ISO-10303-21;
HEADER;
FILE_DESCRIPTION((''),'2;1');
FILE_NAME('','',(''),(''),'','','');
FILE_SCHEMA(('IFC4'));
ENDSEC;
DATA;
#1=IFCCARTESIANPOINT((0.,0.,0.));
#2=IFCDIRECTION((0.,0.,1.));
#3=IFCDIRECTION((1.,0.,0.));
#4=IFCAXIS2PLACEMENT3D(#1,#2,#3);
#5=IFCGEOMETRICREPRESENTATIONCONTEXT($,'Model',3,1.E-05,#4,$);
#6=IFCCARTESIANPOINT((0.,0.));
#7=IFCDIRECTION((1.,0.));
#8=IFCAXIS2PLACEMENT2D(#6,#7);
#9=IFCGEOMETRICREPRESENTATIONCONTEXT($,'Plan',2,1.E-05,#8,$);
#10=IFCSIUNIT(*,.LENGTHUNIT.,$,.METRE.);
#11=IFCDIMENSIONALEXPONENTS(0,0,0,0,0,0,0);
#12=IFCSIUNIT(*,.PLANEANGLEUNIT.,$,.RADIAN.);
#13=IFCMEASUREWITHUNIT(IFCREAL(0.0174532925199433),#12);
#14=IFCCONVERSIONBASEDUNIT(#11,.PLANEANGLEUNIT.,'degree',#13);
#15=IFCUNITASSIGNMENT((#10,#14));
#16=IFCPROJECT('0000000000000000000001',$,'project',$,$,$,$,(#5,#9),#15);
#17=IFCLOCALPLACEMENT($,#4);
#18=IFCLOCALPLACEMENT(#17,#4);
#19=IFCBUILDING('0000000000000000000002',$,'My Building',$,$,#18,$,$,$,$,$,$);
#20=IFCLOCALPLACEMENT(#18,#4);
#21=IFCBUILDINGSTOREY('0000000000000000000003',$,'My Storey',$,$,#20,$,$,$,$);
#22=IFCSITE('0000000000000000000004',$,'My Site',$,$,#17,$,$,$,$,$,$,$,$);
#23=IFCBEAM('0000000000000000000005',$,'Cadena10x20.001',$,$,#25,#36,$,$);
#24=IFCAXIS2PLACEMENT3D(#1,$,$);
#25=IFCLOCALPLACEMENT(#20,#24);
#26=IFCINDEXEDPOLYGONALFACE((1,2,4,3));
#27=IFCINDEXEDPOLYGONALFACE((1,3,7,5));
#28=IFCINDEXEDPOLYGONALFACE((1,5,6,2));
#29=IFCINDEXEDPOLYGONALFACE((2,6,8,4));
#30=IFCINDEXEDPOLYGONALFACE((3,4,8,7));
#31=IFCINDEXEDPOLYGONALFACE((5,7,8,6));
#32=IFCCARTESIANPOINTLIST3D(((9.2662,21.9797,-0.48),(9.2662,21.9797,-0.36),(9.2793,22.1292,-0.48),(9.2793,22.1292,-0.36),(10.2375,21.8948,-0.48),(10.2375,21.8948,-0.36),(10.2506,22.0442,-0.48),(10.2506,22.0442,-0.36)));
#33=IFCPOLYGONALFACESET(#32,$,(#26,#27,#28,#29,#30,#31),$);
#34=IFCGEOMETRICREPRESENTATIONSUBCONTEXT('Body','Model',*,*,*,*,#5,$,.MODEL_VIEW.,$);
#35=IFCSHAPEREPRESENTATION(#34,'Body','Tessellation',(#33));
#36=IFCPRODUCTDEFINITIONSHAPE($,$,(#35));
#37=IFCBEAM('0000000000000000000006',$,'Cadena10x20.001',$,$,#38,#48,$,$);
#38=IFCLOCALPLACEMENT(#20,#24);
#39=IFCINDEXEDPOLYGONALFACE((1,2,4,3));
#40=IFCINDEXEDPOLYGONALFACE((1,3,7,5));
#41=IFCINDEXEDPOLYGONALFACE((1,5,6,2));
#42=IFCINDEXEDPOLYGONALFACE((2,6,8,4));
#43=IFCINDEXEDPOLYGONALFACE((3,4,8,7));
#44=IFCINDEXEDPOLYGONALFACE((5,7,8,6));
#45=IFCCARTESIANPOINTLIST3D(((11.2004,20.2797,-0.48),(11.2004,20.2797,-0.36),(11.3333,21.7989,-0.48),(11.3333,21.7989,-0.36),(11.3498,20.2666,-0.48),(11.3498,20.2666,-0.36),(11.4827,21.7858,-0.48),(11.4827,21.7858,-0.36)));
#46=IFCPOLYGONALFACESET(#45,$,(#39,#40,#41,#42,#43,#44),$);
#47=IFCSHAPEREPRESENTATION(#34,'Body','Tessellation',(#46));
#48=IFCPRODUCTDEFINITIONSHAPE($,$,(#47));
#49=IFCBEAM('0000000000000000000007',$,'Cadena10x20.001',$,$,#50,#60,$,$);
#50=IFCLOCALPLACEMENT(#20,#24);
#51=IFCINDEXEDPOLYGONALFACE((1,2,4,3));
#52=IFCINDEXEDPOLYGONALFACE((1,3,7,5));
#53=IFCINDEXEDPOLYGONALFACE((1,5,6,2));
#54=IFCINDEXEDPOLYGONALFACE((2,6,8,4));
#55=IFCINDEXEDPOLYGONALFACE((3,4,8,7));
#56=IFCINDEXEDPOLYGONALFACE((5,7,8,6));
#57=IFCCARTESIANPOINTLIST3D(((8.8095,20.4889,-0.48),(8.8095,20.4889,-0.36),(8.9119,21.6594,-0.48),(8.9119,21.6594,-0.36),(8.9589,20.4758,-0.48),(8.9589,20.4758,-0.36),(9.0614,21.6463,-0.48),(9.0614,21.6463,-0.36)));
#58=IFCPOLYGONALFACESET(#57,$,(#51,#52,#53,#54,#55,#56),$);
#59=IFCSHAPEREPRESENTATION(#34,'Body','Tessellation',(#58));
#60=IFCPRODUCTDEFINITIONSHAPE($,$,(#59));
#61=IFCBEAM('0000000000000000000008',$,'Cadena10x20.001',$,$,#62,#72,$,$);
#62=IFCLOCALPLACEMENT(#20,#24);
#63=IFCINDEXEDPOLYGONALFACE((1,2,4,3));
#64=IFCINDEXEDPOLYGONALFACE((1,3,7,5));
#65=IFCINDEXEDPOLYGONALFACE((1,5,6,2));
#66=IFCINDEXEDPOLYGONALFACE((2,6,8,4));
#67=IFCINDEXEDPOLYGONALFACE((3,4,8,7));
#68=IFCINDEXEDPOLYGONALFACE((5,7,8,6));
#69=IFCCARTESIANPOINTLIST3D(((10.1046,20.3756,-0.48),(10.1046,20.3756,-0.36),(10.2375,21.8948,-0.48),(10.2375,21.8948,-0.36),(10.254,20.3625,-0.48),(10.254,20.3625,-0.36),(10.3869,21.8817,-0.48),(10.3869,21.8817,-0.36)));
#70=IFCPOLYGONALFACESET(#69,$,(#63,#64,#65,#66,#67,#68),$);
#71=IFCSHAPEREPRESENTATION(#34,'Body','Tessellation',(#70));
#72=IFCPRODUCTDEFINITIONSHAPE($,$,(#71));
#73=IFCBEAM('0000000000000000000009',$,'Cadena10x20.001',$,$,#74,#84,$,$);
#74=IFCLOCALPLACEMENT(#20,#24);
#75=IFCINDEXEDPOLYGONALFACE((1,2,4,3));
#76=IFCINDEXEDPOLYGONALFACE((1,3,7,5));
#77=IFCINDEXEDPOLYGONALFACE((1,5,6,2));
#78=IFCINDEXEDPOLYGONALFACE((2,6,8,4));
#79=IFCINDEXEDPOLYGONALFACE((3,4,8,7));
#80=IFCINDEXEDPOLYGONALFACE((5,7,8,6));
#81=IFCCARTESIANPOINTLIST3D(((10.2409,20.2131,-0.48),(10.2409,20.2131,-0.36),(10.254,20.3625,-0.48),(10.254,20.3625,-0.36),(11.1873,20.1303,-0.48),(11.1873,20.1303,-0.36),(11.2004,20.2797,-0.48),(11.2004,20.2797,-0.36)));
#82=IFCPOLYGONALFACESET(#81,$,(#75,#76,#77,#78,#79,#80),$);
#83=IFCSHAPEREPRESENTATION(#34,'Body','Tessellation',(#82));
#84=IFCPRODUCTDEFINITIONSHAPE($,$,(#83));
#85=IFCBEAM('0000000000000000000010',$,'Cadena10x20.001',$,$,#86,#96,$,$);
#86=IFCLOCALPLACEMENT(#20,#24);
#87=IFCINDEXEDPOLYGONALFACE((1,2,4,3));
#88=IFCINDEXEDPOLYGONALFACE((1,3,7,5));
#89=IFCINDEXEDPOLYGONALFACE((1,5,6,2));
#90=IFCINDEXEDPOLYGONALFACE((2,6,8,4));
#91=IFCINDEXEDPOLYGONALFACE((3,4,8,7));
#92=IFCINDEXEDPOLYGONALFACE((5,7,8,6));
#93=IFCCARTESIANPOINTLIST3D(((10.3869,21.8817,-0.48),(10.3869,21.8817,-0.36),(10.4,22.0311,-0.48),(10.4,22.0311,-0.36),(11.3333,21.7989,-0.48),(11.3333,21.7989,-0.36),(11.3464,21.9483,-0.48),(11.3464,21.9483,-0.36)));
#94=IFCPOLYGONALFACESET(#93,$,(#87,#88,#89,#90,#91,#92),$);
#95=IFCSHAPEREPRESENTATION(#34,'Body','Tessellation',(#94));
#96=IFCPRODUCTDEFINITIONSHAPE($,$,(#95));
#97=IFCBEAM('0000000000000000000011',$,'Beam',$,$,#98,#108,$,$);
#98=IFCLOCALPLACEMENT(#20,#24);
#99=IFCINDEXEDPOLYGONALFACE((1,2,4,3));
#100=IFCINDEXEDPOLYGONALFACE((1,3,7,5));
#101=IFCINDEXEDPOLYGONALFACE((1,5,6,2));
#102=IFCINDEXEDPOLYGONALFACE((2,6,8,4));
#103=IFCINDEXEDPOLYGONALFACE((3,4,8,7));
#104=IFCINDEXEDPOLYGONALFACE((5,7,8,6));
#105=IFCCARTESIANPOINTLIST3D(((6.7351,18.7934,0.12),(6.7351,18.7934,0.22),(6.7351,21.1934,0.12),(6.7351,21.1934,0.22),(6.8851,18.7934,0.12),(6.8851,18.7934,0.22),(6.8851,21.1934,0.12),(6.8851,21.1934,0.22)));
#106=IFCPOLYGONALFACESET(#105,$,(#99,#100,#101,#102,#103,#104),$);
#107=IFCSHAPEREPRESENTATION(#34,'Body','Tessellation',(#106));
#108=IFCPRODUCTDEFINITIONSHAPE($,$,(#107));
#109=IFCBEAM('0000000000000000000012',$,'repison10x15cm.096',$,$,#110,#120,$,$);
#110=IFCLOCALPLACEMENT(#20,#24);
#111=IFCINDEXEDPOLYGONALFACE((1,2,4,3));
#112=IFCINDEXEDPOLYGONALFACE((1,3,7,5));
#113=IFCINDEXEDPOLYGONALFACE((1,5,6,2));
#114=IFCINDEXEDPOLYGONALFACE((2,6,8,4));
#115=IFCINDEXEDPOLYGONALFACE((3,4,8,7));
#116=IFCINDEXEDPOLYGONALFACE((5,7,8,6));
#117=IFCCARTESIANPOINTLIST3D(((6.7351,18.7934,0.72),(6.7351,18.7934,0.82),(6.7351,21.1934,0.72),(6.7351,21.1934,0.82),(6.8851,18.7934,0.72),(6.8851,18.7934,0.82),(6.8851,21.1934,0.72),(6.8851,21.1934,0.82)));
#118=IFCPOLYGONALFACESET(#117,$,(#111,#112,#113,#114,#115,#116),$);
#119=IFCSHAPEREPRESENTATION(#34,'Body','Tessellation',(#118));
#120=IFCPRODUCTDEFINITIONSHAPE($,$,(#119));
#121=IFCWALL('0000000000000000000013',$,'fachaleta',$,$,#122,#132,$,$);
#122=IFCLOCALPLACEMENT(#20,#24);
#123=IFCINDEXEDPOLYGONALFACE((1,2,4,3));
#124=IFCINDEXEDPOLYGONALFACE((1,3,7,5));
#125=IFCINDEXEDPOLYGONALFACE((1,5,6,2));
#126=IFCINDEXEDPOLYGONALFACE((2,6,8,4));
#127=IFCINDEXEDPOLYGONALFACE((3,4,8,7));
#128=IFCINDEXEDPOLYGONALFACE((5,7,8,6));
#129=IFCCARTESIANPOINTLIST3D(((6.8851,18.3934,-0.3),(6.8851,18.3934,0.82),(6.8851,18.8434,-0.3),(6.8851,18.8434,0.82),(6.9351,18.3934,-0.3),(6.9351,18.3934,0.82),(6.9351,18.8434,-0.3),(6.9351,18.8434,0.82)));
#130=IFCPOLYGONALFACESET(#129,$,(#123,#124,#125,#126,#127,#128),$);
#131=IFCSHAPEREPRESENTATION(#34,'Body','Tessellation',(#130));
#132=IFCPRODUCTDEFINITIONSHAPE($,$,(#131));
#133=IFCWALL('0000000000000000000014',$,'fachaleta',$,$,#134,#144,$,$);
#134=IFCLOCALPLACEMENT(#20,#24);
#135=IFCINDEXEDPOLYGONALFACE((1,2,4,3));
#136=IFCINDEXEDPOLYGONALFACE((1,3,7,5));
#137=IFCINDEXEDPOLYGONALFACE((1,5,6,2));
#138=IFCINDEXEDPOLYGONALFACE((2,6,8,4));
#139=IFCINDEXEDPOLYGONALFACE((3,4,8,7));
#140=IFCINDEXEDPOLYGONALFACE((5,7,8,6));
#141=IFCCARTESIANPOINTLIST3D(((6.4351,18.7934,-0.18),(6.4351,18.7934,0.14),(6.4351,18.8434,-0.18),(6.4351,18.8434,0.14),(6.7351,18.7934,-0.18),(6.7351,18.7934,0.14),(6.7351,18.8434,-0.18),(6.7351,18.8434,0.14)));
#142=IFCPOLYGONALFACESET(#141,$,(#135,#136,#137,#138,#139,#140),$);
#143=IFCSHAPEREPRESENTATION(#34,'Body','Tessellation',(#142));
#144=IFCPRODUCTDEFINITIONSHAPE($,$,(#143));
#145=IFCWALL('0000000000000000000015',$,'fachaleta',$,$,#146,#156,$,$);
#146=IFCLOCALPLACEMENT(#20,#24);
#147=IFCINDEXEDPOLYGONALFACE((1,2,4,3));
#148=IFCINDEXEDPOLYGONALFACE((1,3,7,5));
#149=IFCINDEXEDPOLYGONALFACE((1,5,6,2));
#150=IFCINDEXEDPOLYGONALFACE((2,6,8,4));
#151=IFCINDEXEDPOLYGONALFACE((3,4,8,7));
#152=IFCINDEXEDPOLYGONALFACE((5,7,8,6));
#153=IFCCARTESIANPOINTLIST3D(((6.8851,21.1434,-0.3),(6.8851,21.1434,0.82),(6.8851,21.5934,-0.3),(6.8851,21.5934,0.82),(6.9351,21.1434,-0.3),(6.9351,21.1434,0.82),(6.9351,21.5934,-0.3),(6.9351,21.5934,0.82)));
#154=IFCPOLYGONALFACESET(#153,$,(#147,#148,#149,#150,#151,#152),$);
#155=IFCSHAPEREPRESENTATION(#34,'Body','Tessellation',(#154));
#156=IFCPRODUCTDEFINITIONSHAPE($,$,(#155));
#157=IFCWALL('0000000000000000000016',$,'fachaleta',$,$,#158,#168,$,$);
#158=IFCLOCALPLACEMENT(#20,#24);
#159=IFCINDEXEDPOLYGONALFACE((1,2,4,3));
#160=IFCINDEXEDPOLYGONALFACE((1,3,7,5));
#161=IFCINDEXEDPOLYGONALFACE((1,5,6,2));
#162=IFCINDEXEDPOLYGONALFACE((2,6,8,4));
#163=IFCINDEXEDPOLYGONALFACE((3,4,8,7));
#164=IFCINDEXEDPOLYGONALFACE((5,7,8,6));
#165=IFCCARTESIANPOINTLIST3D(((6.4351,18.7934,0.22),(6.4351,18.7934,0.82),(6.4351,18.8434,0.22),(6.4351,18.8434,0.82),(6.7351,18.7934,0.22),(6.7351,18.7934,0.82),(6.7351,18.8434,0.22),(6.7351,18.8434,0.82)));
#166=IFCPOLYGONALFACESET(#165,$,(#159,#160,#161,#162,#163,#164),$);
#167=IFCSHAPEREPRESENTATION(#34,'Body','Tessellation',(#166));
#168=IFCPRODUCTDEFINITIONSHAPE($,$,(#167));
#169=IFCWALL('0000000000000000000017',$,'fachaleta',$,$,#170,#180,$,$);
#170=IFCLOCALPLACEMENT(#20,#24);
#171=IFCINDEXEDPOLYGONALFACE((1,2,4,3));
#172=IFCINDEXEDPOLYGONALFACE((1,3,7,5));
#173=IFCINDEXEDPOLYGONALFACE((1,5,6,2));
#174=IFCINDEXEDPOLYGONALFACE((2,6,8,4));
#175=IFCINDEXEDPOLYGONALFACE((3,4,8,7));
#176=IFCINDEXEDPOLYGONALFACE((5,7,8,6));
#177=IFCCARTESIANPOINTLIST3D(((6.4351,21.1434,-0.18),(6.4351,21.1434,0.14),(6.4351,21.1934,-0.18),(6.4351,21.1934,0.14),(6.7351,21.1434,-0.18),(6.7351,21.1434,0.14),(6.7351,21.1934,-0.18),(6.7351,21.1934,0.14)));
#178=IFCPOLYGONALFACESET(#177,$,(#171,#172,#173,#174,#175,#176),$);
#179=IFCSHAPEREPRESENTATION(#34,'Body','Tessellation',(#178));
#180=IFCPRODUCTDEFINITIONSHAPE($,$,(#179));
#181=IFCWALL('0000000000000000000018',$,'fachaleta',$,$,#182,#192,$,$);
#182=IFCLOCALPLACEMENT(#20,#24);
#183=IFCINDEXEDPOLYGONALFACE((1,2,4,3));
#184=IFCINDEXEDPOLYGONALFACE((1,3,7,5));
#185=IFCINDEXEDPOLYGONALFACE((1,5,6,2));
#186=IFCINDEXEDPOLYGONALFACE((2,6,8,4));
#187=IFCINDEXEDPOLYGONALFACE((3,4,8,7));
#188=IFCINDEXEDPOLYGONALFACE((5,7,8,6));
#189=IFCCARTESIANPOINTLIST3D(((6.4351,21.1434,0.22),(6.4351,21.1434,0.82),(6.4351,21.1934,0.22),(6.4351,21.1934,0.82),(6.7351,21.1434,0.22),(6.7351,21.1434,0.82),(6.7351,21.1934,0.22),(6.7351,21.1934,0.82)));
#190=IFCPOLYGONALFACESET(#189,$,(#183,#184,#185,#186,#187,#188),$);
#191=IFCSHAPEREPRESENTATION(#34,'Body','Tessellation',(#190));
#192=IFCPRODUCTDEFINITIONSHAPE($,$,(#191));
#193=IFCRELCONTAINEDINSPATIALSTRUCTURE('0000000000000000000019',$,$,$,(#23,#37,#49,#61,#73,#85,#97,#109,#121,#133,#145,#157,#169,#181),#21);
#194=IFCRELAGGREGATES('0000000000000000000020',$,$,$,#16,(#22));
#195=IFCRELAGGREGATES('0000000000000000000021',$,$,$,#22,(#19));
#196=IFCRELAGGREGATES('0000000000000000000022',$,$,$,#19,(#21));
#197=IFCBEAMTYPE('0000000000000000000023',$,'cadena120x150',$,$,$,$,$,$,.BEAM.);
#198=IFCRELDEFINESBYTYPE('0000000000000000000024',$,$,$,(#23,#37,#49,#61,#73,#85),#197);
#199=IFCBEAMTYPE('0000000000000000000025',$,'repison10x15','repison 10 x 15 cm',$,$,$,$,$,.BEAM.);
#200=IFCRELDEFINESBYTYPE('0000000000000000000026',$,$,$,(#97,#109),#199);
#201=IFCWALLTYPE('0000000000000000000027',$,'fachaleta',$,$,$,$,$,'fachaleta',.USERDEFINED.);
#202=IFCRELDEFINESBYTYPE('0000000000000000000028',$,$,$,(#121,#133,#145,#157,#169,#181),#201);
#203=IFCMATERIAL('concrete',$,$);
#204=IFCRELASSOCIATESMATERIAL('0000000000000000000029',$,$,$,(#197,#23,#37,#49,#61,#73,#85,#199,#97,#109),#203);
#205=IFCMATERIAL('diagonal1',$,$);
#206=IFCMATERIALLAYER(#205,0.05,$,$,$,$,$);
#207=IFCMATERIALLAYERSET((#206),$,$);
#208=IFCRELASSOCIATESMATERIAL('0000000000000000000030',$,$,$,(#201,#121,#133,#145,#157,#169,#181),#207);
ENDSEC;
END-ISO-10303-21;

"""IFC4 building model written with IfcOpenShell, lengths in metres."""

from ifc_helpers import new_model, entity, si_unit, converted_unit, frame, origin_with_axes, origin_2d_with_axis, place, context, subcontext, project, spatial, indexed_curve, rectangle, outline, extrude, material, layer, layer_set, layer_usage, material_profile, profile_set, profile_usage, type_object, element, save


model = new_model("IFC4")

# Units and contexts
model_context = context("Model", 3, precision=1e-05, world=origin_with_axes())
plan_context = context("Plan", 2, precision=1e-05, world=origin_2d_with_axis())
body_context = subcontext(model_context, "Body", "Model", "MODEL_VIEW")
ifc_project = project(units=[si_unit("LENGTHUNIT", "METRE"), converted_unit("PLANEANGLEUNIT", "degree", entity("IfcReal", 0.0174532925199433), si_unit("PLANEANGLEUNIT", "RADIAN"), dimensions=[0, 0, 0, 0, 0, 0, 0])], contexts=[model_context, plan_context])

# Site, building, storey
site_placement = place(None, origin_with_axes())
site = spatial("IfcSite", under=ifc_project, at=site_placement, Name="My Site")
building_placement = place(site_placement, origin_with_axes())
building = spatial("IfcBuilding", under=site, at=building_placement, Name="My Building")
storey_placement = place(building_placement, origin_with_axes())
storey = spatial("IfcBuildingStorey", under=building, at=storey_placement, Name="My Storey")

# Shared definitions
ifc_material_1 = material(Name="concrete")

# Beams
ifc_material_profile_1 = material_profile(ifc_material_1, rectangle(XDim=0.15, YDim=0.12))
ifc_profile_set_1 = profile_set([ifc_material_profile_1], Name="concrete")
beam_type_1 = type_object("IfcBeamType", Name="cadena120x150", PredefinedType="BEAM", material=ifc_profile_set_1)
ifc_profile_usage_1 = profile_usage(ifc_profile_set_1)
beam_1_placement = place(storey_placement, frame((10.244, 21.9695, -0.42), z_axis=(-0.996195, 0.087155, 0.0), x_axis=(-0.087155, -0.996195, 0.0)))
element("IfcBeam", 1, at=beam_1_placement, inside=storey, type_object=beam_type_1, material=ifc_profile_usage_1, Name="Cadena10x20.001", context=body_context, shape_type="SweptSolid", body=[
    extrude(rectangle(XDim=0.15, YDim=0.12), origin_with_axes(), (0.0, 0.0, 1.0), 0.975),
])
ifc_profile_usage_2 = profile_usage(ifc_profile_set_1)
beam_2_placement = place(storey_placement, frame((11.408, 21.7923, -0.42), z_axis=(-0.087156, -0.996195, 0.0), x_axis=(0.996195, -0.087156, 0.0)))
element("IfcBeam", 2, at=beam_2_placement, inside=storey, type_object=beam_type_1, material=ifc_profile_usage_2, Name="Cadena10x20.001", context=body_context, shape_type="SweptSolid", body=[
    extrude(rectangle(XDim=0.15, YDim=0.12), origin_with_axes(), (0.0, 0.0, 1.0), 1.525),
])
ifc_profile_usage_3 = profile_usage(ifc_profile_set_1)
beam_3_placement = place(storey_placement, frame((8.9866, 21.6528, -0.42), z_axis=(-0.087156, -0.996195, 0.0), x_axis=(0.996195, -0.087156, 0.0)))
element("IfcBeam", 3, at=beam_3_placement, inside=storey, type_object=beam_type_1, material=ifc_profile_usage_3, Name="Cadena10x20.001", context=body_context, shape_type="SweptSolid", body=[
    extrude(rectangle(XDim=0.15, YDim=0.12), origin_with_axes(), (0.0, 0.0, 1.0), 1.175),
])
ifc_profile_usage_4 = profile_usage(ifc_profile_set_1)
beam_4_placement = place(storey_placement, frame((10.3122, 21.8882, -0.42), z_axis=(-0.087156, -0.996195, 0.0), x_axis=(0.996195, -0.087156, 0.0)))
element("IfcBeam", 4, at=beam_4_placement, inside=storey, type_object=beam_type_1, material=ifc_profile_usage_4, Name="Cadena10x20.001", context=body_context, shape_type="SweptSolid", body=[
    extrude(rectangle(XDim=0.15, YDim=0.12), origin_with_axes(), (0.0, 0.0, 1.0), 1.525),
])
ifc_profile_usage_5 = profile_usage(ifc_profile_set_1)
beam_5_placement = place(storey_placement, frame((11.1938, 20.205, -0.42), z_axis=(-0.996195, 0.087155, 0.0), x_axis=(-0.087155, -0.996195, 0.0)))
element("IfcBeam", 5, at=beam_5_placement, inside=storey, type_object=beam_type_1, material=ifc_profile_usage_5, Name="Cadena10x20.001", context=body_context, shape_type="SweptSolid", body=[
    extrude(rectangle(XDim=0.15, YDim=0.12), origin_with_axes(), (0.0, 0.0, 1.0), 0.95),
])
ifc_profile_usage_6 = profile_usage(ifc_profile_set_1)
beam_6_placement = place(storey_placement, frame((11.3398, 21.8736, -0.42), z_axis=(-0.996195, 0.087155, 0.0), x_axis=(-0.087155, -0.996195, 0.0)))
element("IfcBeam", 6, at=beam_6_placement, inside=storey, type_object=beam_type_1, material=ifc_profile_usage_6, Name="Cadena10x20.001", context=body_context, shape_type="SweptSolid", body=[
    extrude(rectangle(XDim=0.15, YDim=0.12), origin_with_axes(), (0.0, 0.0, 1.0), 0.95),
])
ifc_material_profile_2 = material_profile(ifc_material_1, rectangle(XDim=0.15, YDim=0.1))
ifc_profile_set_2 = profile_set([ifc_material_profile_2])
ifc_profile_usage_7 = profile_usage(ifc_profile_set_2, cardinal=5)
beam_type_2 = type_object("IfcBeamType", Name="repison10x15", Description="repison 10 x 15 cm", PredefinedType="BEAM", material=ifc_profile_set_2)
beam_7_placement = place(storey_placement, frame((6.8101, 18.7934, 0.17), z_axis=(0.0, 1.0, 0.0), x_axis=(-1.0, 0.0, 0.0)))
element("IfcBeam", 7, at=beam_7_placement, inside=storey, type_object=beam_type_2, material=ifc_profile_usage_7, Name="Beam", context=body_context, shape_type="SweptSolid", body=[
    extrude(rectangle(XDim=0.15, YDim=0.1), origin_with_axes(), (0.0, 0.0, 1.0), 2.4),
])
ifc_profile_usage_8 = profile_usage(ifc_profile_set_2, cardinal=5)
beam_8_placement = place(storey_placement, frame((6.8101, 18.7934, 0.77), z_axis=(0.0, 1.0, 0.0), x_axis=(-1.0, 0.0, 0.0)))
element("IfcBeam", 8, at=beam_8_placement, inside=storey, type_object=beam_type_2, material=ifc_profile_usage_8, Name="repison10x15cm.096", context=body_context, shape_type="SweptSolid", body=[
    extrude(rectangle(XDim=0.15, YDim=0.1), origin_with_axes(), (0.0, 0.0, 1.0), 2.4),
])

# Walls
ifc_material_2 = material(Name="diagonal1")
ifc_layer_1 = layer(ifc_material_2, 0.05)
ifc_layer_set_1 = layer_set([ifc_layer_1])
ifc_layer_usage_1 = layer_usage(ifc_layer_set_1, "AXIS2", "POSITIVE", 0.0)
wall_type_1 = type_object("IfcWallType", Name="fachaleta", ElementType="fachaleta", PredefinedType="USERDEFINED", material=ifc_layer_set_1)
wall_1_placement = place(storey_placement, frame((6.8851, 18.8434, -0.3), z_axis=(0.0, 0.0, 1.0), x_axis=(0.0, -1.0, 0.0)))
element("IfcWall", 9, at=wall_1_placement, inside=storey, type_object=wall_type_1, material=ifc_layer_usage_1, Name="fachaleta", context=body_context, shape_type="SweptSolid", body=[
    extrude(outline(indexed_curve([(0.0, 0.0), (0.0, 0.05), (0.45, 0.05), (0.45, 0.0), (0.0, 0.0)], self_intersect=False)), origin_with_axes(), (0.0, 0.0, 1.0), 1.12),
])
ifc_layer_usage_2 = layer_usage(ifc_layer_set_1, "AXIS2", "POSITIVE", 0.0)
wall_2_placement = place(storey_placement, frame((6.7351, 18.8434, -0.18), z_axis=(0.0, 0.0, 1.0), x_axis=(-1.0, 0.000001, 0.0)))
element("IfcWall", 10, at=wall_2_placement, inside=storey, type_object=wall_type_1, material=ifc_layer_usage_2, Name="fachaleta", context=body_context, shape_type="SweptSolid", body=[
    extrude(outline(indexed_curve([(0.0, 0.0), (0.0, 0.05), (0.3, 0.05), (0.3, 0.0), (0.0, 0.0)], self_intersect=False)), origin_with_axes(), (0.0, 0.0, 1.0), 0.32),
])
ifc_layer_usage_3 = layer_usage(ifc_layer_set_1, "AXIS2", "POSITIVE", 0.0)
wall_3_placement = place(storey_placement, frame((6.8851, 21.5934, -0.3), z_axis=(0.0, 0.0, 1.0), x_axis=(0.0, -1.0, 0.0)))
element("IfcWall", 11, at=wall_3_placement, inside=storey, type_object=wall_type_1, material=ifc_layer_usage_3, Name="fachaleta", context=body_context, shape_type="SweptSolid", body=[
    extrude(outline(indexed_curve([(0.0, 0.0), (0.0, 0.05), (0.45, 0.05), (0.45, 0.0), (0.0, 0.0)], self_intersect=False)), origin_with_axes(), (0.0, 0.0, 1.0), 1.12),
])
ifc_layer_usage_4 = layer_usage(ifc_layer_set_1, "AXIS2", "POSITIVE", 0.0)
wall_4_placement = place(storey_placement, frame((6.7351, 18.8434, 0.22), z_axis=(0.0, 0.0, 1.0), x_axis=(-1.0, 0.000001, 0.0)))
element("IfcWall", 12, at=wall_4_placement, inside=storey, type_object=wall_type_1, material=ifc_layer_usage_4, Name="fachaleta", context=body_context, shape_type="SweptSolid", body=[
    extrude(outline(indexed_curve([(0.0, 0.0), (0.0, 0.05), (0.3, 0.05), (0.3, 0.0), (0.0, 0.0)], self_intersect=False)), origin_with_axes(), (0.0, 0.0, 1.0), 0.6),
])
ifc_layer_usage_5 = layer_usage(ifc_layer_set_1, "AXIS2", "POSITIVE", 0.0)
wall_5_placement = place(storey_placement, frame((6.7351, 21.1934, -0.18), z_axis=(0.0, 0.0, 1.0), x_axis=(-1.0, 0.000001, 0.0)))
element("IfcWall", 13, at=wall_5_placement, inside=storey, type_object=wall_type_1, material=ifc_layer_usage_5, Name="fachaleta", context=body_context, shape_type="SweptSolid", body=[
    extrude(outline(indexed_curve([(0.0, 0.0), (0.0, 0.05), (0.3, 0.05), (0.3, 0.0), (0.0, 0.0)], self_intersect=False)), origin_with_axes(), (0.0, 0.0, 1.0), 0.32),
])
ifc_layer_usage_6 = layer_usage(ifc_layer_set_1, "AXIS2", "POSITIVE", 0.0)
wall_6_placement = place(storey_placement, frame((6.7351, 21.1934, 0.22), z_axis=(0.0, 0.0, 1.0), x_axis=(-1.0, 0.000001, 0.0)))
element("IfcWall", 14, at=wall_6_placement, inside=storey, type_object=wall_type_1, material=ifc_layer_usage_6, Name="fachaleta", context=body_context, shape_type="SweptSolid", body=[
    extrude(outline(indexed_curve([(0.0, 0.0), (0.0, 0.05), (0.3, 0.05), (0.3, 0.0), (0.0, 0.0)], self_intersect=False)), origin_with_axes(), (0.0, 0.0, 1.0), 0.6),
])

save(model, "model.ifc")
